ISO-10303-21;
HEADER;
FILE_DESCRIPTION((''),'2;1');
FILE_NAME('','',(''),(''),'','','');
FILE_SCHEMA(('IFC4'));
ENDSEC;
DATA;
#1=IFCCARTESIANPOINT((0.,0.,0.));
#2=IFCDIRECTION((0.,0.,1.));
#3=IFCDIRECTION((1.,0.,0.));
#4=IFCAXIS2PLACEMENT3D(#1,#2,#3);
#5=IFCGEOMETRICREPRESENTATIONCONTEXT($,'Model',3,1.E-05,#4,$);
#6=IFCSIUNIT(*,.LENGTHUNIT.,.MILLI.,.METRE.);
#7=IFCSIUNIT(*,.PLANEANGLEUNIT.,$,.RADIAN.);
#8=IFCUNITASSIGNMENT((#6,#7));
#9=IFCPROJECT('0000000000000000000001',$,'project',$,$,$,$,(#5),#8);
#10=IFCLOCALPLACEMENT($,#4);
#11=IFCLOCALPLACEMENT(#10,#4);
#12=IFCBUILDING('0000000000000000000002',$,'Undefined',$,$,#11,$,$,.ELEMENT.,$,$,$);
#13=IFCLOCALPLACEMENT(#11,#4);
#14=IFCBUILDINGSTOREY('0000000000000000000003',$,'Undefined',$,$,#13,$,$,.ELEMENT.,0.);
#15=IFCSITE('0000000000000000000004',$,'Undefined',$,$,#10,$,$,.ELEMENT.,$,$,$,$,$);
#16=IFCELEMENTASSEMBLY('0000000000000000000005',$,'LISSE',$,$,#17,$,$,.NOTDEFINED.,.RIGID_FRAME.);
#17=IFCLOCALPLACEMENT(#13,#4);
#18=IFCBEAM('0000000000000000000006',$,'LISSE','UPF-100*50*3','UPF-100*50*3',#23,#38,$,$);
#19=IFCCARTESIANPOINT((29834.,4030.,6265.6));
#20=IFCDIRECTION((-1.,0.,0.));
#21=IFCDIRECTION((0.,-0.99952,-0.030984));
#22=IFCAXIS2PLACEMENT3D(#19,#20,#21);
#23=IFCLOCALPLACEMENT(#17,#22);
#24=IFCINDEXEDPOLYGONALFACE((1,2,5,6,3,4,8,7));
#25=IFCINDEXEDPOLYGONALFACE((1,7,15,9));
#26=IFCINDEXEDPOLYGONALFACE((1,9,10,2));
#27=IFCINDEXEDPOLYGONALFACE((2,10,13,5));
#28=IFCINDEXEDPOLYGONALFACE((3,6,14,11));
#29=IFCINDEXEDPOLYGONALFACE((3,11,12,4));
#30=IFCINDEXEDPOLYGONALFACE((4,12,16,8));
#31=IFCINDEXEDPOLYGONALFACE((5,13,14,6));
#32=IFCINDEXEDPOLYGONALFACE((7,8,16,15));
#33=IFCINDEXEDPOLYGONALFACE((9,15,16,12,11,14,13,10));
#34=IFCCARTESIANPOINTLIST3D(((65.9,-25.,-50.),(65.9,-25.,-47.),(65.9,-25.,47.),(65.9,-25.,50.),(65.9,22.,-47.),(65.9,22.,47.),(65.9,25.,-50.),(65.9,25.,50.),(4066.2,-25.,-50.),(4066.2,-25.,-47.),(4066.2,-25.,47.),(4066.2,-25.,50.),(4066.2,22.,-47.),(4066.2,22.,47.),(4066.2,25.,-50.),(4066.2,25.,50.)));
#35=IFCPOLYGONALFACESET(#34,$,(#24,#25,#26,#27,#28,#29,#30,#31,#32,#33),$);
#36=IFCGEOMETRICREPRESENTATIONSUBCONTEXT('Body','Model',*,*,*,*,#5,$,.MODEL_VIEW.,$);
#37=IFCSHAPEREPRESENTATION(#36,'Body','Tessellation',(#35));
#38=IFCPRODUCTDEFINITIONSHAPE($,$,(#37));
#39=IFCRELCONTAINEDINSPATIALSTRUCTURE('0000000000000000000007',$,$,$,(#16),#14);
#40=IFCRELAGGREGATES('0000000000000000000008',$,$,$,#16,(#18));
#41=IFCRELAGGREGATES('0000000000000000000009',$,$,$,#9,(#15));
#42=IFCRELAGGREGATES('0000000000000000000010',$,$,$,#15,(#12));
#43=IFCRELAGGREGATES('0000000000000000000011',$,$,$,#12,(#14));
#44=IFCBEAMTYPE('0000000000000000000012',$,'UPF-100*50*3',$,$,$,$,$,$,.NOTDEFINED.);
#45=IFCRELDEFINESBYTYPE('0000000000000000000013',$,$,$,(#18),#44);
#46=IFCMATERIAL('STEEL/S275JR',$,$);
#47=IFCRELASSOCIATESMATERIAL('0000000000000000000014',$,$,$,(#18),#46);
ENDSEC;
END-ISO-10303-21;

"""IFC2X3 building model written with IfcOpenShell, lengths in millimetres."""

from ifc_helpers import new_model, si_unit, frame, origin_with_axes, origin_2d_with_axis, place, context, subcontext, project, spatial, u_section, extrude, clip, halfspace, material, type_object, element, aggregate, save


model = new_model("IFC2X3")

# Units and contexts
model_context = context("Model", 3, precision=1e-05, world=origin_with_axes())
body_context = subcontext(model_context, "Body", "Model", "MODEL_VIEW")
ifc_project = project(units=[si_unit("LENGTHUNIT", "METRE", prefix="MILLI"), si_unit("PLANEANGLEUNIT", "RADIAN")], contexts=[model_context])

# Site, building, storey
site_placement = place(None, origin_with_axes())
site = spatial("IfcSite", under=ifc_project, at=site_placement, Name="Undefined", CompositionType="ELEMENT")
building_placement = place(site_placement, origin_with_axes())
building = spatial("IfcBuilding", under=site, at=building_placement, Name="Undefined", CompositionType="ELEMENT")
storey_placement = place(building_placement, origin_with_axes())
storey = spatial("IfcBuildingStorey", under=building, at=storey_placement, Name="Undefined", CompositionType="ELEMENT", Elevation=0.0)

# Shared definitions
ifc_material_1 = material(Name="STEEL/S275JR")

# Element assembly, beam
beam_type_1 = type_object("IfcBeamType", Name="UPF-100*50*3", PredefinedType="NOTDEFINED")
assembly_1_placement = place(storey_placement, origin_with_axes())
assembly_1 = element("IfcElementAssembly", 1, at=assembly_1_placement, inside=storey, Name="LISSE", AssemblyPlace="NOTDEFINED", PredefinedType="RIGID_FRAME")
beam_1_placement = place(assembly_1_placement, frame((29834.0, 4030.0, 6265.6), z_axis=(-1.0, 0.0, 0.0), x_axis=(0.0, -0.99952, -0.030984)))
beam_1 = element("IfcBeam", 2, at=beam_1_placement, type_object=beam_type_1, material=ifc_material_1, Name="LISSE", Description="UPF-100*50*3", ObjectType="UPF-100*50*3", context=body_context, shape_type="Clipping", body=[
    clip(clip(extrude(u_section(Depth=100.0, FlangeWidth=50.0, WebThickness=3.0, FlangeThickness=3.0, at=origin_2d_with_axis()), frame((4069.3, 0.0, 0.0), z_axis=(-1.0, 0.0, 0.0), x_axis=(0.0, -1.0, 0.0)), (0.0, 0.0, 1.0), 4006.6), halfspace(frame((4066.2, 25.0, -50.0), z_axis=(1.0, 0.0, 0.0), x_axis=(0.0, 0.0, -1.0)), False)), halfspace(frame((65.9, 17.2, -50.0), z_axis=(1.0, 0.0, 0.0), x_axis=(0.0, 0.0, -1.0)), True)),
])

aggregate(assembly_1, [beam_1])

save(model, "model.ifc")
